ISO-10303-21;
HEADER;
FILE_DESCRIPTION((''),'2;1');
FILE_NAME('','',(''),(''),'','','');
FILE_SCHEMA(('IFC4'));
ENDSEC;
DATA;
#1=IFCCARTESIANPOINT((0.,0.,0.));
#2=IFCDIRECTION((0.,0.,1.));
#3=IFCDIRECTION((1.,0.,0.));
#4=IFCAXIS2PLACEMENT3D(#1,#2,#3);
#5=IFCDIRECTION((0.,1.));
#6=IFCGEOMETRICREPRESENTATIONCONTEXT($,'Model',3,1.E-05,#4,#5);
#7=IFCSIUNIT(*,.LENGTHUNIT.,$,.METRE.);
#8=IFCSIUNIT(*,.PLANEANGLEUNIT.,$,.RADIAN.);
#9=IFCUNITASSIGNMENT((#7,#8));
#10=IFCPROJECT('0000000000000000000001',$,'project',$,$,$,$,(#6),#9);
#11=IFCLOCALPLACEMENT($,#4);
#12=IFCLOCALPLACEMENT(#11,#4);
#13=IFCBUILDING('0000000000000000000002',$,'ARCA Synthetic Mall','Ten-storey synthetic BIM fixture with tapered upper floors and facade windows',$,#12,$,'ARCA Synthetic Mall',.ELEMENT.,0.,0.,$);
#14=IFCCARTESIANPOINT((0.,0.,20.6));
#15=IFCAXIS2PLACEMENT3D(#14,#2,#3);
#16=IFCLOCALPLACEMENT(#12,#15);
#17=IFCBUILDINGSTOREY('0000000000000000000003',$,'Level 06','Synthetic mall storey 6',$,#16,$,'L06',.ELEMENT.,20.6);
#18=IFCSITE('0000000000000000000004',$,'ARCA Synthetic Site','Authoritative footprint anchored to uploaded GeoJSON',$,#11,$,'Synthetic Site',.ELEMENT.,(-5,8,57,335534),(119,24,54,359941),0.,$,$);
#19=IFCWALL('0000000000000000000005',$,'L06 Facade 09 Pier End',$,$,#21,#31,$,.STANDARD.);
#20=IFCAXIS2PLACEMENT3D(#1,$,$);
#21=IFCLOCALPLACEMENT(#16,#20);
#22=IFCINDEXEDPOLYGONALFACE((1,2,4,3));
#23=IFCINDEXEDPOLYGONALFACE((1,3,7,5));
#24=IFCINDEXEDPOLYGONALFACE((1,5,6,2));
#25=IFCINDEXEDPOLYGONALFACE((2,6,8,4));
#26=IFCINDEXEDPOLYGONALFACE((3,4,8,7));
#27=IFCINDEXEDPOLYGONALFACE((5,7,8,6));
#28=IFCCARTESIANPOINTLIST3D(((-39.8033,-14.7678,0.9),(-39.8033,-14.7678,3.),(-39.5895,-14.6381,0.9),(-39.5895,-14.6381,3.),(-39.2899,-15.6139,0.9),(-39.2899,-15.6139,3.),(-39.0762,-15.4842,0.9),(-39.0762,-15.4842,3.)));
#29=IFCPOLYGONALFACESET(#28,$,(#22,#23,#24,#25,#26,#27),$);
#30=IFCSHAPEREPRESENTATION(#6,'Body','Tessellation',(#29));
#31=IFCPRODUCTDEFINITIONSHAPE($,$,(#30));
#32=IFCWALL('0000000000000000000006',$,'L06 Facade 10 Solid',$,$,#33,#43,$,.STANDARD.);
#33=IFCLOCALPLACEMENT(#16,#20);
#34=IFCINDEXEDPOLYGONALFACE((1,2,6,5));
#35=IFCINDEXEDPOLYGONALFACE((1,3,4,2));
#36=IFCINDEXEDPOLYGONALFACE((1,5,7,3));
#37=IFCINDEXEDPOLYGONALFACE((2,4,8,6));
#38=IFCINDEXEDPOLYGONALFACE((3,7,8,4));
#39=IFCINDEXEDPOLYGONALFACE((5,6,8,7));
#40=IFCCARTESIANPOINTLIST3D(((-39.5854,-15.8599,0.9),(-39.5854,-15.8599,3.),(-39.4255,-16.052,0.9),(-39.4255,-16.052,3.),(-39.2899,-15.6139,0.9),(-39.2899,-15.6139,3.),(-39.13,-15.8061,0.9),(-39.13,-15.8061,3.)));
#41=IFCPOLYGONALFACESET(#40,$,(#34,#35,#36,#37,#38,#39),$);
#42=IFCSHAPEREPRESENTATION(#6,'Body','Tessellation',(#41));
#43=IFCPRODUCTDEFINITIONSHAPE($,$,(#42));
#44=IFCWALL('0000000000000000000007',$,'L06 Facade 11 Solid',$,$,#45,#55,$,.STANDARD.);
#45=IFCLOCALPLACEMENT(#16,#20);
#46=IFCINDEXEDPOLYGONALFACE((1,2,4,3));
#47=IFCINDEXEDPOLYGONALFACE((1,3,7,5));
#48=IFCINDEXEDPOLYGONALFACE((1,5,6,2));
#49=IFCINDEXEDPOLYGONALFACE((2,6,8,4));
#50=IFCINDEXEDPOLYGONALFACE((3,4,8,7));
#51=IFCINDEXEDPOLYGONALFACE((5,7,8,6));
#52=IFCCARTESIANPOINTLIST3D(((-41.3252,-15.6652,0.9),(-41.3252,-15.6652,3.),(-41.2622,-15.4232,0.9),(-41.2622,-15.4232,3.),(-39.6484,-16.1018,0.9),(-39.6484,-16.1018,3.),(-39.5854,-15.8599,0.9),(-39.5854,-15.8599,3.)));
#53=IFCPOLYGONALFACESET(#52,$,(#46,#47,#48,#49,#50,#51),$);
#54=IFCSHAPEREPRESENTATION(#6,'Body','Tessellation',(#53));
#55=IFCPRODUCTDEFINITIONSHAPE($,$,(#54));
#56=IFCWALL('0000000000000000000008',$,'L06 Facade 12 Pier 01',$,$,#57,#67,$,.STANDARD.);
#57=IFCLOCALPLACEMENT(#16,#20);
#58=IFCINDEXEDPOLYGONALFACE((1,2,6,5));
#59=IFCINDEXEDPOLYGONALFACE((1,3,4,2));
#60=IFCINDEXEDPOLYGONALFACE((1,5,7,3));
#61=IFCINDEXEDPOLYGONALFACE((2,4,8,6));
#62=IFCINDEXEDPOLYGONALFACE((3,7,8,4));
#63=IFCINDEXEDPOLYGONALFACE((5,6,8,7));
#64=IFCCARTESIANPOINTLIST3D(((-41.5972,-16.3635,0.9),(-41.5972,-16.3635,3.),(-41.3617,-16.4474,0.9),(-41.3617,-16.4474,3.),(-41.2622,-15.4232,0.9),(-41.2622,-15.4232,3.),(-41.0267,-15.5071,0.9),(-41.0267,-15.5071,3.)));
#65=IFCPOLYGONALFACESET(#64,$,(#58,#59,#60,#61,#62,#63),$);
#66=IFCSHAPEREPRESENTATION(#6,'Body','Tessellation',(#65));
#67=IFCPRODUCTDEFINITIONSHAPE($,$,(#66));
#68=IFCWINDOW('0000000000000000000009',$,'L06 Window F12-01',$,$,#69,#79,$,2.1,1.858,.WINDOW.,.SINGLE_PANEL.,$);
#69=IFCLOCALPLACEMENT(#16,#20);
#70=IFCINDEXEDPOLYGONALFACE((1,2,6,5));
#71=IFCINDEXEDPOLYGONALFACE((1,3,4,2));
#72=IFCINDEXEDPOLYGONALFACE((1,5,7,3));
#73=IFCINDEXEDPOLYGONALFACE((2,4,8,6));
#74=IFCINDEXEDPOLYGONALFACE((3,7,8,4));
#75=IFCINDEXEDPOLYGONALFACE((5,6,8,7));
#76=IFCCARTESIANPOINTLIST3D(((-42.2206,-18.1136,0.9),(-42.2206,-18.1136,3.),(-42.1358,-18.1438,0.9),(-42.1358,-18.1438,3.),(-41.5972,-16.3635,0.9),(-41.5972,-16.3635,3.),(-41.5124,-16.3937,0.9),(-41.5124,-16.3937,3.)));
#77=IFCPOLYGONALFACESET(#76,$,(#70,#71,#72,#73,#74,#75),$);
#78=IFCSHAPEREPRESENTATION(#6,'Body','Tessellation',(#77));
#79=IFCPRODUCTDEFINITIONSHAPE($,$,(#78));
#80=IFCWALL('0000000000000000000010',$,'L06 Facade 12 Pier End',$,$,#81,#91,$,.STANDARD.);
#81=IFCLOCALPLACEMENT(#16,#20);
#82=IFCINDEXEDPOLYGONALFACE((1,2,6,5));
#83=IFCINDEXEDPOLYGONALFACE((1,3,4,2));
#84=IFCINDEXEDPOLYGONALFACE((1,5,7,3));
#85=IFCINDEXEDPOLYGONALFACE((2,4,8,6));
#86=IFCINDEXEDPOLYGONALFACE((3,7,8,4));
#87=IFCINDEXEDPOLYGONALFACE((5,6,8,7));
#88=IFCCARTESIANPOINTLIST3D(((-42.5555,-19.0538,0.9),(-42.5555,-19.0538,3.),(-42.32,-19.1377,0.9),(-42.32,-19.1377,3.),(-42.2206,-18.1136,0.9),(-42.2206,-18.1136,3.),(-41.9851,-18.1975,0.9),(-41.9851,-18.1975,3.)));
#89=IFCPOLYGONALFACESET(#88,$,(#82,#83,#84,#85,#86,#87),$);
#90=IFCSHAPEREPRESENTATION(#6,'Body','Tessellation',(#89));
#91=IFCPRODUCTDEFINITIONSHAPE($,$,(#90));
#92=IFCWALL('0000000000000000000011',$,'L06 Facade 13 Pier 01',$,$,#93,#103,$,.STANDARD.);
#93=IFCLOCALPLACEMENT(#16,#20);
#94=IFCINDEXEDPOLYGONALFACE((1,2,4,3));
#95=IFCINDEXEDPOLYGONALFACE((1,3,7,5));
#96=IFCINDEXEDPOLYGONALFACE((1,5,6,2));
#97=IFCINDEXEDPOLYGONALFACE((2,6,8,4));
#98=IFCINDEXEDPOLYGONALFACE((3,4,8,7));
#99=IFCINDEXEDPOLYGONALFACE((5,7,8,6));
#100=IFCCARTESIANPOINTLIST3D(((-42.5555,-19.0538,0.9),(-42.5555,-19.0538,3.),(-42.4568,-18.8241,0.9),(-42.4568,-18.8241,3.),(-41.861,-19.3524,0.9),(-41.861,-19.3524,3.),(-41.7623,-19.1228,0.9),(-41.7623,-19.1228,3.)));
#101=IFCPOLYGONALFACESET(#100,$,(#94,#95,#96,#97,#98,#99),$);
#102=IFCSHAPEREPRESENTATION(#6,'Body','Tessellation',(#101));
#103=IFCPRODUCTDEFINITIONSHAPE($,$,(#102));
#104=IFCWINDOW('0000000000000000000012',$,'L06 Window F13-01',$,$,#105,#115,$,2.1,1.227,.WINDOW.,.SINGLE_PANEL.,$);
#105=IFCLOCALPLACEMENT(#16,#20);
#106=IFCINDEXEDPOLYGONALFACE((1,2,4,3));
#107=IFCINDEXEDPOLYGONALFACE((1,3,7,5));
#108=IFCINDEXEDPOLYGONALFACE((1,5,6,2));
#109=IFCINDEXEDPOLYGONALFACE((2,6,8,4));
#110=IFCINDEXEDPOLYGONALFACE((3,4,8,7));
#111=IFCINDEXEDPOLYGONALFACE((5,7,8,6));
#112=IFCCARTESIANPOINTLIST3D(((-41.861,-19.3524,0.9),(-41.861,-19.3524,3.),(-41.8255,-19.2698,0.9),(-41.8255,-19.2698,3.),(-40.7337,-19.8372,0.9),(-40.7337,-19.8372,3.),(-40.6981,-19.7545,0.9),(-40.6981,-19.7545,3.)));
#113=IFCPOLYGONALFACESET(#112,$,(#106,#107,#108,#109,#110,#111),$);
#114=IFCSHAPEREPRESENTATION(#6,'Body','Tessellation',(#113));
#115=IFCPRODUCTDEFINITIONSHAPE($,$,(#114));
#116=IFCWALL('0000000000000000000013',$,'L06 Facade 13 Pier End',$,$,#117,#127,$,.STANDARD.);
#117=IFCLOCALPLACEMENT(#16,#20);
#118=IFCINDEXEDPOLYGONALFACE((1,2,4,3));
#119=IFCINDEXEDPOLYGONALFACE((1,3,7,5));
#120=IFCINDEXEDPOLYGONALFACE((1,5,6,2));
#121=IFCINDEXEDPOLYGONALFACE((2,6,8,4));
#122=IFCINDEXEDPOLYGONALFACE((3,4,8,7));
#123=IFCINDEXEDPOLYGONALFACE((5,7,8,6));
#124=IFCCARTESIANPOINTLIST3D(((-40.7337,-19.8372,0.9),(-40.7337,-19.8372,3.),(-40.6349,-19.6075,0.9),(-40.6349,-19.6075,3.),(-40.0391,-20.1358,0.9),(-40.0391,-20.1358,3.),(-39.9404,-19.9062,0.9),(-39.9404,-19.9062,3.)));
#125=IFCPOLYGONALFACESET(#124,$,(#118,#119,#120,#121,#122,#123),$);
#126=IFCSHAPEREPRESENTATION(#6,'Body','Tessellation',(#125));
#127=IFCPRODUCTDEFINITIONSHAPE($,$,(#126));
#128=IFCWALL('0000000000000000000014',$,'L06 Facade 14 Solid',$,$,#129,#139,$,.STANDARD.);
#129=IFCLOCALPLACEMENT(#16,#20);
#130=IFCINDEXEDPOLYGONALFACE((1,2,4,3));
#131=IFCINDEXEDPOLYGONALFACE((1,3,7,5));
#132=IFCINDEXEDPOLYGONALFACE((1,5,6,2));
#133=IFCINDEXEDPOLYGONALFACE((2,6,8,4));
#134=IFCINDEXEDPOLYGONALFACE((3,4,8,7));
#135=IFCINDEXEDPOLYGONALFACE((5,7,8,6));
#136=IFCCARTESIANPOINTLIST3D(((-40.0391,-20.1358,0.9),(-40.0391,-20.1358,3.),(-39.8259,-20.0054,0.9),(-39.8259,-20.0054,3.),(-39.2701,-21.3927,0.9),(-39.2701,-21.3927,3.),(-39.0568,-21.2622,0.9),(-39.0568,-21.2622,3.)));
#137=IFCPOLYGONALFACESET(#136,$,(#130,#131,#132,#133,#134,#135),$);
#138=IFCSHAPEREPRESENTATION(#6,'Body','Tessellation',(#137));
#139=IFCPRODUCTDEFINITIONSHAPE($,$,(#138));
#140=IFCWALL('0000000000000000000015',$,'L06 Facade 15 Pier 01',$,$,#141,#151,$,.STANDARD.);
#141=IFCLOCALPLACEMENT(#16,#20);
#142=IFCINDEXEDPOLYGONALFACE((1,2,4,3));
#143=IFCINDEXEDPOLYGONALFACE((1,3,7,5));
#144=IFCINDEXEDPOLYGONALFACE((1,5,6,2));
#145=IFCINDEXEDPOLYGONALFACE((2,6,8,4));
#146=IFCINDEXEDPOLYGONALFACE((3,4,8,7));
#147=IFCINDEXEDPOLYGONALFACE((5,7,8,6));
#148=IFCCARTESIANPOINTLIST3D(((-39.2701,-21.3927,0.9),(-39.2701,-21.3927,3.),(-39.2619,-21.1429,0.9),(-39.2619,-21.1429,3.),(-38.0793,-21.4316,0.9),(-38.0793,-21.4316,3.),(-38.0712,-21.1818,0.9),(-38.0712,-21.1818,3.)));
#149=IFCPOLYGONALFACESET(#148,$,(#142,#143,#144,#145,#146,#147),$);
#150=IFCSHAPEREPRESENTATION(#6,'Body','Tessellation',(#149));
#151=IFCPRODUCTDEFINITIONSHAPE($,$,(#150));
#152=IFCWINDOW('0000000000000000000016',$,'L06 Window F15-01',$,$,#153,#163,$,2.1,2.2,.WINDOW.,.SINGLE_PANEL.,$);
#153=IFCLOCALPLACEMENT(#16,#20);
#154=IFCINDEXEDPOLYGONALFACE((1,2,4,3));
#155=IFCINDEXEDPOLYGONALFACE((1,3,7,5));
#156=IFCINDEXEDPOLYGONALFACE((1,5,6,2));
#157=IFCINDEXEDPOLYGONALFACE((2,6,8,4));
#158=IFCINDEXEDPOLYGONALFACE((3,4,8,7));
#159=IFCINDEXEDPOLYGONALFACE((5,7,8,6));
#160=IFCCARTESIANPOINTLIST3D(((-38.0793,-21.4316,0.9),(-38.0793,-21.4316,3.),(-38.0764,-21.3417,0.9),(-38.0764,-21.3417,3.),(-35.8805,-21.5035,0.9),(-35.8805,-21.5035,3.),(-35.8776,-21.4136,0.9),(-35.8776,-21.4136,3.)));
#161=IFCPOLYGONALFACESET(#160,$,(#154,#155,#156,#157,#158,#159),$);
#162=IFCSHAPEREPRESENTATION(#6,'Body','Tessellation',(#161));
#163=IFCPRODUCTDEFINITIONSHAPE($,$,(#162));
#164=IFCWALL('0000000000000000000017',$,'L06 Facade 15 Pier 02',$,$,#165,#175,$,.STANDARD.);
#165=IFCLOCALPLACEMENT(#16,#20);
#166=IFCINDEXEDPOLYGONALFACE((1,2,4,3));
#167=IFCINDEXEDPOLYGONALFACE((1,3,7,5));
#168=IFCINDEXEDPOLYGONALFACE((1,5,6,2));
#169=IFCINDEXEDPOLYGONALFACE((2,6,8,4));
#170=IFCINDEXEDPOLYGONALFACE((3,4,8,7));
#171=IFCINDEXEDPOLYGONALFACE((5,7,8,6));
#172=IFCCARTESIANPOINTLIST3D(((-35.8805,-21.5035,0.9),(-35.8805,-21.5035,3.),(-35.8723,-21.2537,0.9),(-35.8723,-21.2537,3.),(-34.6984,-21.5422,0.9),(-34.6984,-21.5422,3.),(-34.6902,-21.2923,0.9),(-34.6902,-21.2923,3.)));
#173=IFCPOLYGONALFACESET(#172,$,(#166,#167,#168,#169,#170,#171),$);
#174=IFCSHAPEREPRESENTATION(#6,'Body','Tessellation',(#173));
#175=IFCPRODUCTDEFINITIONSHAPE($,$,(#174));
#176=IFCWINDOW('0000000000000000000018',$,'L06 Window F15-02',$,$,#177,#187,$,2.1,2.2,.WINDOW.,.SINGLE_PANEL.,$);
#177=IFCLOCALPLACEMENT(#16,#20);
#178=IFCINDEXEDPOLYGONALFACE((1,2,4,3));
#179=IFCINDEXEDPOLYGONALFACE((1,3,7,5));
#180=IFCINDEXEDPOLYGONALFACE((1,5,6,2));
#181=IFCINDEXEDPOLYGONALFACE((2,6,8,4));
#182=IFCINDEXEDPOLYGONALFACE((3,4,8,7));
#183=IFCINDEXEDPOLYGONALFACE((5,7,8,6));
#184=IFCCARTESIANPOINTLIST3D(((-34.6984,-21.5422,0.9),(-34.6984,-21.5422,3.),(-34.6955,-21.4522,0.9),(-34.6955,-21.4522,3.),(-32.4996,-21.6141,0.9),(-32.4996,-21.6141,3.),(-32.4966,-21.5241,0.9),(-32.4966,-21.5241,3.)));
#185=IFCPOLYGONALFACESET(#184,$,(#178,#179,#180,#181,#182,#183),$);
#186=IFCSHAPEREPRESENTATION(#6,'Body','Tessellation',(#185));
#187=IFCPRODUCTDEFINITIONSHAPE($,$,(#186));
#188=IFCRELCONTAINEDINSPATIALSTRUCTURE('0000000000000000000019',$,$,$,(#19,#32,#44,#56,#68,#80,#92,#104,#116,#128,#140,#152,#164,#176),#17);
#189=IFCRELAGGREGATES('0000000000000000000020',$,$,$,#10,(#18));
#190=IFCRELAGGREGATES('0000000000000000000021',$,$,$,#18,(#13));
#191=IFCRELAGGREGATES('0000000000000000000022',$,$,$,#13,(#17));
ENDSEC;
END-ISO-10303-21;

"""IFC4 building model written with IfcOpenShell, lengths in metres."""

from ifc_helpers import new_model, si_unit, direction, frame, origin_with_axes, place, context, project, spatial, polyline, outline, extrude, element, save


model = new_model("IFC4")

# Units and contexts
model_context = context("Model", 3, precision=1e-05, world=origin_with_axes(), true_north=direction((0.0, 1.0)))
ifc_project = project(units=[si_unit("LENGTHUNIT", "METRE"), si_unit("PLANEANGLEUNIT", "RADIAN")], contexts=[model_context])

# Site, building, storey
site_placement = place(None, origin_with_axes())
site = spatial("IfcSite", under=ifc_project, at=site_placement, Name="ARCA Synthetic Site", Description="Authoritative footprint anchored to uploaded GeoJSON", LongName="Synthetic Site", CompositionType="ELEMENT", RefLatitude=(-5, 8, 57, 335534), RefLongitude=(119, 24, 54, 359941), RefElevation=0.0)
building_placement = place(site_placement, origin_with_axes())
building = spatial("IfcBuilding", under=site, at=building_placement, Name="ARCA Synthetic Mall", Description="Ten-storey synthetic BIM fixture with tapered upper floors and facade windows", LongName="ARCA Synthetic Mall", CompositionType="ELEMENT", ElevationOfRefHeight=0.0, ElevationOfTerrain=0.0)
storey_placement = place(building_placement, frame((0.0, 0.0, 20.6), z_axis=(0.0, 0.0, 1.0), x_axis=(1.0, 0.0, 0.0)))
storey = spatial("IfcBuildingStorey", under=building, at=storey_placement, Name="Level 06", Description="Synthetic mall storey 6", LongName="L06", CompositionType="ELEMENT", Elevation=20.6)

# Walls
wall_1_placement = place(storey_placement, frame((0.0, 0.0, 0.9), z_axis=(0.0, 0.0, 1.0), x_axis=(1.0, 0.0, 0.0)))
element("IfcWall", 1, at=wall_1_placement, inside=storey, Name="L06 Facade 09 Pier End", PredefinedType="STANDARD", context=model_context, shape_type="SweptSolid", body=[
    extrude(outline(polyline([(-39.8033, -14.7678), (-39.2899, -15.6139), (-39.0762, -15.4842), (-39.5895, -14.6381), (-39.8033, -14.7678)])), origin_with_axes(), (0.0, 0.0, 1.0), 2.1),
])
wall_2_placement = place(storey_placement, frame((0.0, 0.0, 0.9), z_axis=(0.0, 0.0, 1.0), x_axis=(1.0, 0.0, 0.0)))
element("IfcWall", 2, at=wall_2_placement, inside=storey, Name="L06 Facade 10 Solid", PredefinedType="STANDARD", context=model_context, shape_type="SweptSolid", body=[
    extrude(outline(polyline([(-39.2899, -15.6139), (-39.5854, -15.8599), (-39.4255, -16.052), (-39.13, -15.8061), (-39.2899, -15.6139)])), origin_with_axes(), (0.0, 0.0, 1.0), 2.1),
])
wall_3_placement = place(storey_placement, frame((0.0, 0.0, 0.9), z_axis=(0.0, 0.0, 1.0), x_axis=(1.0, 0.0, 0.0)))
element("IfcWall", 3, at=wall_3_placement, inside=storey, Name="L06 Facade 11 Solid", PredefinedType="STANDARD", context=model_context, shape_type="SweptSolid", body=[
    extrude(outline(polyline([(-39.5854, -15.8599), (-41.2622, -15.4232), (-41.3252, -15.6652), (-39.6484, -16.1018), (-39.5854, -15.8599)])), origin_with_axes(), (0.0, 0.0, 1.0), 2.1),
])
wall_4_placement = place(storey_placement, frame((0.0, 0.0, 0.9), z_axis=(0.0, 0.0, 1.0), x_axis=(1.0, 0.0, 0.0)))
element("IfcWall", 4, at=wall_4_placement, inside=storey, Name="L06 Facade 12 Pier 01", PredefinedType="STANDARD", context=model_context, shape_type="SweptSolid", body=[
    extrude(outline(polyline([(-41.2622, -15.4232), (-41.5972, -16.3635), (-41.3617, -16.4474), (-41.0267, -15.5071), (-41.2622, -15.4232)])), origin_with_axes(), (0.0, 0.0, 1.0), 2.1),
])

# Window
window_1_placement = place(storey_placement, frame((0.0, 0.0, 0.9), z_axis=(0.0, 0.0, 1.0), x_axis=(1.0, 0.0, 0.0)))
element("IfcWindow", 5, at=window_1_placement, inside=storey, Name="L06 Window F12-01", OverallHeight=2.1, OverallWidth=1.858, PartitioningType="SINGLE_PANEL", PredefinedType="WINDOW", context=model_context, shape_type="SweptSolid", body=[
    extrude(outline(polyline([(-41.5972, -16.3635), (-42.2206, -18.1136), (-42.1358, -18.1438), (-41.5124, -16.3937), (-41.5972, -16.3635)])), origin_with_axes(), (0.0, 0.0, 1.0), 2.1),
])

# Walls
wall_5_placement = place(storey_placement, frame((0.0, 0.0, 0.9), z_axis=(0.0, 0.0, 1.0), x_axis=(1.0, 0.0, 0.0)))
element("IfcWall", 6, at=wall_5_placement, inside=storey, Name="L06 Facade 12 Pier End", PredefinedType="STANDARD", context=model_context, shape_type="SweptSolid", body=[
    extrude(outline(polyline([(-42.2206, -18.1136), (-42.5555, -19.0538), (-42.32, -19.1377), (-41.9851, -18.1975), (-42.2206, -18.1136)])), origin_with_axes(), (0.0, 0.0, 1.0), 2.1),
])
wall_6_placement = place(storey_placement, frame((0.0, 0.0, 0.9), z_axis=(0.0, 0.0, 1.0), x_axis=(1.0, 0.0, 0.0)))
element("IfcWall", 7, at=wall_6_placement, inside=storey, Name="L06 Facade 13 Pier 01", PredefinedType="STANDARD", context=model_context, shape_type="SweptSolid", body=[
    extrude(outline(polyline([(-42.5555, -19.0538), (-41.861, -19.3524), (-41.7623, -19.1228), (-42.4568, -18.8241), (-42.5555, -19.0538)])), origin_with_axes(), (0.0, 0.0, 1.0), 2.1),
])

# Window
window_2_placement = place(storey_placement, frame((0.0, 0.0, 0.9), z_axis=(0.0, 0.0, 1.0), x_axis=(1.0, 0.0, 0.0)))
element("IfcWindow", 8, at=window_2_placement, inside=storey, Name="L06 Window F13-01", OverallHeight=2.1, OverallWidth=1.227, PartitioningType="SINGLE_PANEL", PredefinedType="WINDOW", context=model_context, shape_type="SweptSolid", body=[
    extrude(outline(polyline([(-41.861, -19.3524), (-40.7337, -19.8372), (-40.6981, -19.7545), (-41.8255, -19.2698), (-41.861, -19.3524)])), origin_with_axes(), (0.0, 0.0, 1.0), 2.1),
])

# Walls
wall_7_placement = place(storey_placement, frame((0.0, 0.0, 0.9), z_axis=(0.0, 0.0, 1.0), x_axis=(1.0, 0.0, 0.0)))
element("IfcWall", 9, at=wall_7_placement, inside=storey, Name="L06 Facade 13 Pier End", PredefinedType="STANDARD", context=model_context, shape_type="SweptSolid", body=[
    extrude(outline(polyline([(-40.7337, -19.8372), (-40.0391, -20.1358), (-39.9404, -19.9062), (-40.6349, -19.6075), (-40.7337, -19.8372)])), origin_with_axes(), (0.0, 0.0, 1.0), 2.1),
])
wall_8_placement = place(storey_placement, frame((0.0, 0.0, 0.9), z_axis=(0.0, 0.0, 1.0), x_axis=(1.0, 0.0, 0.0)))
element("IfcWall", 10, at=wall_8_placement, inside=storey, Name="L06 Facade 14 Solid", PredefinedType="STANDARD", context=model_context, shape_type="SweptSolid", body=[
    extrude(outline(polyline([(-40.0391, -20.1358), (-39.2701, -21.3927), (-39.0568, -21.2622), (-39.8259, -20.0054), (-40.0391, -20.1358)])), origin_with_axes(), (0.0, 0.0, 1.0), 2.1),
])
wall_9_placement = place(storey_placement, frame((0.0, 0.0, 0.9), z_axis=(0.0, 0.0, 1.0), x_axis=(1.0, 0.0, 0.0)))
element("IfcWall", 11, at=wall_9_placement, inside=storey, Name="L06 Facade 15 Pier 01", PredefinedType="STANDARD", context=model_context, shape_type="SweptSolid", body=[
    extrude(outline(polyline([(-39.2701, -21.3927), (-38.0793, -21.4316), (-38.0712, -21.1818), (-39.2619, -21.1429), (-39.2701, -21.3927)])), origin_with_axes(), (0.0, 0.0, 1.0), 2.1),
])

# Window
window_3_placement = place(storey_placement, frame((0.0, 0.0, 0.9), z_axis=(0.0, 0.0, 1.0), x_axis=(1.0, 0.0, 0.0)))
element("IfcWindow", 12, at=window_3_placement, inside=storey, Name="L06 Window F15-01", OverallHeight=2.1, OverallWidth=2.2, PartitioningType="SINGLE_PANEL", PredefinedType="WINDOW", context=model_context, shape_type="SweptSolid", body=[
    extrude(outline(polyline([(-38.0793, -21.4316), (-35.8805, -21.5035), (-35.8776, -21.4136), (-38.0764, -21.3417), (-38.0793, -21.4316)])), origin_with_axes(), (0.0, 0.0, 1.0), 2.1),
])

# Wall
wall_10_placement = place(storey_placement, frame((0.0, 0.0, 0.9), z_axis=(0.0, 0.0, 1.0), x_axis=(1.0, 0.0, 0.0)))
element("IfcWall", 13, at=wall_10_placement, inside=storey, Name="L06 Facade 15 Pier 02", PredefinedType="STANDARD", context=model_context, shape_type="SweptSolid", body=[
    extrude(outline(polyline([(-35.8805, -21.5035), (-34.6984, -21.5422), (-34.6902, -21.2923), (-35.8723, -21.2537), (-35.8805, -21.5035)])), origin_with_axes(), (0.0, 0.0, 1.0), 2.1),
])

# Window
window_4_placement = place(storey_placement, frame((0.0, 0.0, 0.9), z_axis=(0.0, 0.0, 1.0), x_axis=(1.0, 0.0, 0.0)))
element("IfcWindow", 14, at=window_4_placement, inside=storey, Name="L06 Window F15-02", OverallHeight=2.1, OverallWidth=2.2, PartitioningType="SINGLE_PANEL", PredefinedType="WINDOW", context=model_context, shape_type="SweptSolid", body=[
    extrude(outline(polyline([(-34.6984, -21.5422), (-32.4996, -21.6141), (-32.4966, -21.5241), (-34.6955, -21.4522), (-34.6984, -21.5422)])), origin_with_axes(), (0.0, 0.0, 1.0), 2.1),
])

save(model, "model.ifc")
